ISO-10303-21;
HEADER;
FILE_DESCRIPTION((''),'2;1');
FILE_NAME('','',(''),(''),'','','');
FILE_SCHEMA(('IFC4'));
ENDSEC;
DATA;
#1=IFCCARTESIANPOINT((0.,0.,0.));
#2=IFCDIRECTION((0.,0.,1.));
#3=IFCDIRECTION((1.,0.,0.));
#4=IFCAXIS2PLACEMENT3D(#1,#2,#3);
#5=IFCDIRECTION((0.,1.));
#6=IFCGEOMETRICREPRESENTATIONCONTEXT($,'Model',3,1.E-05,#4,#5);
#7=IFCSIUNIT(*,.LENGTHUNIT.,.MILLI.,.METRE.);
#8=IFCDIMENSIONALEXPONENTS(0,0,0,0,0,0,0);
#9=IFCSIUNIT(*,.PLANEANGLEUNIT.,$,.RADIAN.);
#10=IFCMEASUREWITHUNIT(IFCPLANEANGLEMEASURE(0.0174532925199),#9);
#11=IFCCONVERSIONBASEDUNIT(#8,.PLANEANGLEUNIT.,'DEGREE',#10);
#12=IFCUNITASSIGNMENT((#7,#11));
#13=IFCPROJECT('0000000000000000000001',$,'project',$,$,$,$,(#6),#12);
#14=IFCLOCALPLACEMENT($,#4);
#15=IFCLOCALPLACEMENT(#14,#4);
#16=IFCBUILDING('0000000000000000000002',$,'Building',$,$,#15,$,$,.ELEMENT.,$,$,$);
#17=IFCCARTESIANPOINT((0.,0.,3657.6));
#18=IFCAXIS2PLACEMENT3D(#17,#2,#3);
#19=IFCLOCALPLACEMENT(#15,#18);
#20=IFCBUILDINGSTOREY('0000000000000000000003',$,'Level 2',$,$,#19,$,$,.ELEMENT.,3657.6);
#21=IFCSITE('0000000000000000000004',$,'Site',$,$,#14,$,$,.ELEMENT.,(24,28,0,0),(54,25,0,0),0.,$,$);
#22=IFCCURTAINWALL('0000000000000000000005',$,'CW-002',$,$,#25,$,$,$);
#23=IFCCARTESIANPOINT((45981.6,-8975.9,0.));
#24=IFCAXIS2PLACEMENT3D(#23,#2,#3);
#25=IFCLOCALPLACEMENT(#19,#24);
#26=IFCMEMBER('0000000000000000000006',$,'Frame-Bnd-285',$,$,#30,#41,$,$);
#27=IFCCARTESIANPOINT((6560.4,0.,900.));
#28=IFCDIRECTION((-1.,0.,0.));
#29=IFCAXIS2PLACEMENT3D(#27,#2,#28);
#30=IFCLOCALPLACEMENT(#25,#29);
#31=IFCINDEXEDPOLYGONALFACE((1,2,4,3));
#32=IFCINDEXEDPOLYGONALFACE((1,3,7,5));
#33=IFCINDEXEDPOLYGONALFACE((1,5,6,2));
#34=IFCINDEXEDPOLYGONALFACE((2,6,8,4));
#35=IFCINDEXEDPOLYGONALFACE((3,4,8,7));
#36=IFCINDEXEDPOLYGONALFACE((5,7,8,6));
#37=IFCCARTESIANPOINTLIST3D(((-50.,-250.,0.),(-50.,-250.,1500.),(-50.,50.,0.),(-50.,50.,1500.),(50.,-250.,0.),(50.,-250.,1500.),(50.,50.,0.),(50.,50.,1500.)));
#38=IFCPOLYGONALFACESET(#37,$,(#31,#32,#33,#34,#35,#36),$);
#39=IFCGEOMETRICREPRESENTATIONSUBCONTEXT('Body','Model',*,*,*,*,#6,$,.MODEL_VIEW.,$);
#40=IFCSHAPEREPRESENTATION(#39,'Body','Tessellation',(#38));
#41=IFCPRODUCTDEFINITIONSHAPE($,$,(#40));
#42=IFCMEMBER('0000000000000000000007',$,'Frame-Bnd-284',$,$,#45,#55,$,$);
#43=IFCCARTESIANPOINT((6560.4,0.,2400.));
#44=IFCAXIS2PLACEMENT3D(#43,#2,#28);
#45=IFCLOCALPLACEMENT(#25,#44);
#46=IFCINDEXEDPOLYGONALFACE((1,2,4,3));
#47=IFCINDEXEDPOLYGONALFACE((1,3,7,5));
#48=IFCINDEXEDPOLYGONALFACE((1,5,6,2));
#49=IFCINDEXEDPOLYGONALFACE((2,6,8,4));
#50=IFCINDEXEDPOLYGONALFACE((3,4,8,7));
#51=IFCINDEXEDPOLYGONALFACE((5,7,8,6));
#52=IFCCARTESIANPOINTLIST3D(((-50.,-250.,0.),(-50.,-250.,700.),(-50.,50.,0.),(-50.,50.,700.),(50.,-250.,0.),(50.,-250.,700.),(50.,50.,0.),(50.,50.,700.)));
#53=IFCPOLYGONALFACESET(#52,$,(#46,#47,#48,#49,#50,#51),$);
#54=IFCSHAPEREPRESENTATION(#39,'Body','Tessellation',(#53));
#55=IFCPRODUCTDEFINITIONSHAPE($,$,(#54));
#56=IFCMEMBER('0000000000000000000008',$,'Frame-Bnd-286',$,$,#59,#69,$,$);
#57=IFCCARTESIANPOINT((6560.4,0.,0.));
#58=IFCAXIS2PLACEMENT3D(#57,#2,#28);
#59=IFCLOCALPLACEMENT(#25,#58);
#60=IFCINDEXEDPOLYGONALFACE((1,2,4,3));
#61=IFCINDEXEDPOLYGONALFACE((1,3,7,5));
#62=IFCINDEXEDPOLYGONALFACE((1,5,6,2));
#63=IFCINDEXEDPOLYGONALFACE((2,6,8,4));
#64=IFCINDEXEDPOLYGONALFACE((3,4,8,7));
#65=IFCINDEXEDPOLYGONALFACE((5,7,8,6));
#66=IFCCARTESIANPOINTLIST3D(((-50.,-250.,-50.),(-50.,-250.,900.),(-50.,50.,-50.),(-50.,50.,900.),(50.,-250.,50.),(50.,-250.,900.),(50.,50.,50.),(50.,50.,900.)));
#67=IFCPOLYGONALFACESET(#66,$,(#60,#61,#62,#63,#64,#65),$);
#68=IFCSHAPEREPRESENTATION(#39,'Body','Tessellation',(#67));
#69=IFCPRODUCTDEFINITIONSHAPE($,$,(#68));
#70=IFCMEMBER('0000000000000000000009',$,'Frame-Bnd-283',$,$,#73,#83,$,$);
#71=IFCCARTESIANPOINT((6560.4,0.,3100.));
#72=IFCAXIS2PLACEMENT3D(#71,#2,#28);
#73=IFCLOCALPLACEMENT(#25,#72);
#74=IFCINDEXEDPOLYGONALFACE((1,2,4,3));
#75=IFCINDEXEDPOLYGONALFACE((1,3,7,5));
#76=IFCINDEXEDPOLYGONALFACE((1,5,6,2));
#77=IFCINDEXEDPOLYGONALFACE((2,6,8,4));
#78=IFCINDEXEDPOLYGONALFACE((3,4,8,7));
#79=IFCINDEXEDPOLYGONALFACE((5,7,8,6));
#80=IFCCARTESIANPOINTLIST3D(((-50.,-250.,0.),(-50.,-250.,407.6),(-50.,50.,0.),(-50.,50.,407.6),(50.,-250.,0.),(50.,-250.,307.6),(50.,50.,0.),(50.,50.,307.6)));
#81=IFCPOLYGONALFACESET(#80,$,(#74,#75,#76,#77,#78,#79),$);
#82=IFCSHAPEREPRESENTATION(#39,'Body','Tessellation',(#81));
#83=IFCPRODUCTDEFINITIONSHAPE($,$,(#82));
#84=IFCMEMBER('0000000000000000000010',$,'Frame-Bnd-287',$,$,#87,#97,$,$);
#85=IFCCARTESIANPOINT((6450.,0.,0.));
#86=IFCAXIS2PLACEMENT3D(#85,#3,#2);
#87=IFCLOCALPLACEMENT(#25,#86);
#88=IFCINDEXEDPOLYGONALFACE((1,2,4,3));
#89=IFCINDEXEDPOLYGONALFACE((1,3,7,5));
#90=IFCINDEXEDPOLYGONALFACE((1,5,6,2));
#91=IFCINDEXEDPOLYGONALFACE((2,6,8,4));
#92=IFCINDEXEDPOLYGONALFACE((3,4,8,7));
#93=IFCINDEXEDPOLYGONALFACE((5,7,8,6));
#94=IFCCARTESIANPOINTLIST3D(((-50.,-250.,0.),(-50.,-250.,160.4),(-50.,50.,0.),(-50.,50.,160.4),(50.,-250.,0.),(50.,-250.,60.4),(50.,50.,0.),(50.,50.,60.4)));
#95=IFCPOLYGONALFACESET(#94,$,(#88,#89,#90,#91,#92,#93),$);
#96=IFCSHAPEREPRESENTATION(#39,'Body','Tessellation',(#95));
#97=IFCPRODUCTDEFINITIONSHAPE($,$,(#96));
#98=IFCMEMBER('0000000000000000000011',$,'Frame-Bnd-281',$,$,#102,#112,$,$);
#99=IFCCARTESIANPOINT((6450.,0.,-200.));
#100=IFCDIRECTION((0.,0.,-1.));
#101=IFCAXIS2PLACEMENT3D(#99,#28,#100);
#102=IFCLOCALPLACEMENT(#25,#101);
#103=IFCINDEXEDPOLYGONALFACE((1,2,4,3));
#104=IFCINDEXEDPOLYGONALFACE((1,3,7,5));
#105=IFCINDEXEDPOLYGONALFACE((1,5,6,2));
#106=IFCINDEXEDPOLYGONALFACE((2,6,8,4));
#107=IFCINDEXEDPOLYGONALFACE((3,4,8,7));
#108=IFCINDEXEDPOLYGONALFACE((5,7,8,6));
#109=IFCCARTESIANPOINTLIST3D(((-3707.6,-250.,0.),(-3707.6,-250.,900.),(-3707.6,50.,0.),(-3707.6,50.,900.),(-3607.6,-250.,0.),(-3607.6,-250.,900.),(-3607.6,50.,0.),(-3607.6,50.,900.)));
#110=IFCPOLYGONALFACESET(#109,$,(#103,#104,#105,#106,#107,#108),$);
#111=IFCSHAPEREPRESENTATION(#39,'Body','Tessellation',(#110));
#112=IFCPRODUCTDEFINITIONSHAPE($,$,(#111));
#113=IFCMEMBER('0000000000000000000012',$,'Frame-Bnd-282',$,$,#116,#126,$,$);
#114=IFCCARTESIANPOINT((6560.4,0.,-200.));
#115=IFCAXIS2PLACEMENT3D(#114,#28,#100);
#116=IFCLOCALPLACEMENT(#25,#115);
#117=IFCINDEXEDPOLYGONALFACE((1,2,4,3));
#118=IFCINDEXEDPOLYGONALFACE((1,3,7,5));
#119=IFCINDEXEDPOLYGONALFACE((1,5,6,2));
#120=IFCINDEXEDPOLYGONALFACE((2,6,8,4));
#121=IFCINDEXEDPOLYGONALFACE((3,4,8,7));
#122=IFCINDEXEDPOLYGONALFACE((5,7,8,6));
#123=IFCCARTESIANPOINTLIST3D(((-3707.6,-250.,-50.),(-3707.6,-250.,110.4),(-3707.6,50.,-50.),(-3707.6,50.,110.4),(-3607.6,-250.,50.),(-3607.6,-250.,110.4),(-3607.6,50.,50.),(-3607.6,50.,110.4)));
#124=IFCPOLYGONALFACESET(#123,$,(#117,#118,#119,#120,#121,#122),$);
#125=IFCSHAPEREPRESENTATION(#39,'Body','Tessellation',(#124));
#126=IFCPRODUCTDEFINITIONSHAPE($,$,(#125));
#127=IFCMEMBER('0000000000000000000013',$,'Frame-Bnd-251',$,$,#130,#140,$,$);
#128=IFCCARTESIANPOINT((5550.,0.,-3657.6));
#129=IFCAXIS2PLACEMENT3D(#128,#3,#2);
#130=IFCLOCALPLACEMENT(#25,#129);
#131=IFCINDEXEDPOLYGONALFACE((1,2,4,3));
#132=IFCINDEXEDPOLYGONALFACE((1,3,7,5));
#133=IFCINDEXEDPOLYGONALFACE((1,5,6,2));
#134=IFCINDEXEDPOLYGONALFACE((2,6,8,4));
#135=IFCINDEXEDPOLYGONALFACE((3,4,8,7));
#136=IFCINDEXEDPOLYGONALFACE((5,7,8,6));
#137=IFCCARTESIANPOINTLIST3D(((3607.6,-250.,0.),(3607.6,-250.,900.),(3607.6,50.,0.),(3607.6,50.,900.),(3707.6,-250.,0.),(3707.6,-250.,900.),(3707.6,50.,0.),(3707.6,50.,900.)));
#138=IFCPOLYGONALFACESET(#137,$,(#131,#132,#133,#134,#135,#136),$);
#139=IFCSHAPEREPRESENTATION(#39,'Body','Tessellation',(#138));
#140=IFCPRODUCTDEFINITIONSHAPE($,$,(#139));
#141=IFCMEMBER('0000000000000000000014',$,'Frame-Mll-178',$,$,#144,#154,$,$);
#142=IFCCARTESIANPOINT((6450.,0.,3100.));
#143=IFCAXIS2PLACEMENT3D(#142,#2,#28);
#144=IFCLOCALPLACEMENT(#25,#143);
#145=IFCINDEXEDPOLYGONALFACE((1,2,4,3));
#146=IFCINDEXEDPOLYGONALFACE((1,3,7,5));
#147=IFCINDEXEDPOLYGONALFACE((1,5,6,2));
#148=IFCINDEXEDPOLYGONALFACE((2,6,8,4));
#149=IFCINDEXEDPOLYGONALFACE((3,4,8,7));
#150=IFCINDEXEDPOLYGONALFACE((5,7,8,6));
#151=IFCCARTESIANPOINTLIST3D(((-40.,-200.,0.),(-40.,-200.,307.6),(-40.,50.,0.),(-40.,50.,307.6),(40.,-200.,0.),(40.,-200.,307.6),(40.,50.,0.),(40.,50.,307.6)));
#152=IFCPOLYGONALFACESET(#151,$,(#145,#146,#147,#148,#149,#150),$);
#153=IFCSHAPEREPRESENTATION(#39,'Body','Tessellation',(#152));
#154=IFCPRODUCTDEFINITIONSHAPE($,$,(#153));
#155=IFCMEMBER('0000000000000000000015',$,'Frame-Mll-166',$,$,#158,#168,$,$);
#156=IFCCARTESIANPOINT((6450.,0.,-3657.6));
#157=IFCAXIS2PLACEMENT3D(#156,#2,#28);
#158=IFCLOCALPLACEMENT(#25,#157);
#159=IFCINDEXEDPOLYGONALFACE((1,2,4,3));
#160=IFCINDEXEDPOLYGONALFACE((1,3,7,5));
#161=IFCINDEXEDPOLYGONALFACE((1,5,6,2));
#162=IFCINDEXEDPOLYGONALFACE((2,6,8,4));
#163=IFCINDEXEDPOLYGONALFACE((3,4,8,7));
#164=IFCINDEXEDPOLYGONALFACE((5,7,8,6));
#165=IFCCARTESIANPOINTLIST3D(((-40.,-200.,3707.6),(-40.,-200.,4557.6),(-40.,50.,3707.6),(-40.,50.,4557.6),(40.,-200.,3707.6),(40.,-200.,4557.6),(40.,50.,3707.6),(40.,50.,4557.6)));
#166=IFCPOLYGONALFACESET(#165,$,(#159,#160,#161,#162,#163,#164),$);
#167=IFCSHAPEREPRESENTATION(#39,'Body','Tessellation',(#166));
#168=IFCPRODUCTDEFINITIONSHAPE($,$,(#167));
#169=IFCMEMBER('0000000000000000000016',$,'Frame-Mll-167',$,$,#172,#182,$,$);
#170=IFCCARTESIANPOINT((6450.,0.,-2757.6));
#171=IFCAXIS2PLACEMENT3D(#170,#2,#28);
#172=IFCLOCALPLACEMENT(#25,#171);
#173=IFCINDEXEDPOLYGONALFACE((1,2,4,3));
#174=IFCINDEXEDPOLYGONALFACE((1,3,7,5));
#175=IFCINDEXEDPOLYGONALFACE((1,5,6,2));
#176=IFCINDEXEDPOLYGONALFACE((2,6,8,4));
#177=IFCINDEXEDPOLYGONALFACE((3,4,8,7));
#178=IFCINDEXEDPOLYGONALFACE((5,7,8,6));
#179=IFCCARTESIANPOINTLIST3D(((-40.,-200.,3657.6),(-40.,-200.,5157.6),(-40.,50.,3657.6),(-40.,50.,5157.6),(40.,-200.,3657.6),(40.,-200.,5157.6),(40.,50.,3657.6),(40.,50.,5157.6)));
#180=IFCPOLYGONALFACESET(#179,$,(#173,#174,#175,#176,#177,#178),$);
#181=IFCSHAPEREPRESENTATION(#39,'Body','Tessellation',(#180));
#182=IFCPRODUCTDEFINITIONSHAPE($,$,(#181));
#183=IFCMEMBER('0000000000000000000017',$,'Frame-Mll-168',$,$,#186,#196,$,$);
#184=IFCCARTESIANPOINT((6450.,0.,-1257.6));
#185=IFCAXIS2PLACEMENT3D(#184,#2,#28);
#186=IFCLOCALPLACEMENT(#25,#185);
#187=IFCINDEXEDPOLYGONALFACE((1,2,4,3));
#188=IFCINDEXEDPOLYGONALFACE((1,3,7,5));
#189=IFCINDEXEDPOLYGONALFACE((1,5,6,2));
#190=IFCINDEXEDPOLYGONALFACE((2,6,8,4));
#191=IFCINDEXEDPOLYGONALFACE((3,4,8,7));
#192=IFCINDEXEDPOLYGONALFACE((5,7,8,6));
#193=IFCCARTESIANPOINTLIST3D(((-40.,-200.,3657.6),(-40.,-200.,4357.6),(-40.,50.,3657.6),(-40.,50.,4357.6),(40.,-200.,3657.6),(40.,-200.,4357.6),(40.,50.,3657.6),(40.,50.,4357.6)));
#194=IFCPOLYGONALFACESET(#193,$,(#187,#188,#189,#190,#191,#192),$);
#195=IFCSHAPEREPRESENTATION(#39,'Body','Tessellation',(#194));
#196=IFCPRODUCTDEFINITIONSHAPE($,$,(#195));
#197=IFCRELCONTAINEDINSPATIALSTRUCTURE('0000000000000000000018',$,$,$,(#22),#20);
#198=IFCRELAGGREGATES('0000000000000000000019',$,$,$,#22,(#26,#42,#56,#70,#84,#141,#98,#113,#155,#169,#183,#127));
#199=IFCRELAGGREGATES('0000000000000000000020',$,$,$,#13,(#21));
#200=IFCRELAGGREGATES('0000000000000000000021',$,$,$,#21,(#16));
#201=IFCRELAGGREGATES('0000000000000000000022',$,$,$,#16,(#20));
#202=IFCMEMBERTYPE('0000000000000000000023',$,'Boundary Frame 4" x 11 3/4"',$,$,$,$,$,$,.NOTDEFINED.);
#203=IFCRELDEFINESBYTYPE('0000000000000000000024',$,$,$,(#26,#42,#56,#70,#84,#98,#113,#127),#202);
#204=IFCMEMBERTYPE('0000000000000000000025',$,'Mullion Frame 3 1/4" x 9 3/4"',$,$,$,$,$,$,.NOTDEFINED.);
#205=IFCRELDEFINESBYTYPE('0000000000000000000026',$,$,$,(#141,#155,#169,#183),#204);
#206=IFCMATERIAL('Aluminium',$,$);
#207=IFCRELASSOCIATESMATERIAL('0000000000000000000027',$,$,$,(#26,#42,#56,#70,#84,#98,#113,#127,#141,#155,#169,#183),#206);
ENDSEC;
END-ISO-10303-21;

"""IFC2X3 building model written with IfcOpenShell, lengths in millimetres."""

from ifc_helpers import new_model, entity, si_unit, converted_unit, direction, frame, origin_with_axes, place, context, subcontext, project, spatial, polyline, outline, extrude, clip, halfspace, material, type_object, element, aggregate, save


model = new_model("IFC2X3")

# Units and contexts
model_context = context("Model", 3, precision=1e-05, world=origin_with_axes(), true_north=direction((0.0, 1.0)))
body_context = subcontext(model_context, "Body", "Model", "MODEL_VIEW")
ifc_project = project(units=[si_unit("LENGTHUNIT", "METRE", prefix="MILLI"), converted_unit("PLANEANGLEUNIT", "DEGREE", entity("IfcPlaneAngleMeasure", 0.0174532925199), si_unit("PLANEANGLEUNIT", "RADIAN"), dimensions=[0, 0, 0, 0, 0, 0, 0])], contexts=[model_context])

# Site, building, storey
site_placement = place(None, origin_with_axes())
site = spatial("IfcSite", under=ifc_project, at=site_placement, Name="Site", CompositionType="ELEMENT", RefLatitude=(24, 28, 0, 0), RefLongitude=(54, 25, 0, 0), RefElevation=0.0)
building_placement = place(site_placement, origin_with_axes())
building = spatial("IfcBuilding", under=site, at=building_placement, Name="Building", CompositionType="ELEMENT")
storey_placement = place(building_placement, frame((0.0, 0.0, 3657.6), z_axis=(0.0, 0.0, 1.0), x_axis=(1.0, 0.0, 0.0)))
storey = spatial("IfcBuildingStorey", under=building, at=storey_placement, Name="Level 2", CompositionType="ELEMENT", Elevation=3657.6)

# Curtain wall, members
curtain_wall_placement = place(storey_placement, frame((45981.6, -8975.9, 0.0), z_axis=(0.0, 0.0, 1.0), x_axis=(1.0, 0.0, 0.0)))
curtain_wall = element("IfcCurtainWall", 1, at=curtain_wall_placement, inside=storey, Name="CW-002")
ifc_material_1 = material(Name="Aluminium")
member_type_1 = type_object("IfcMemberType", Name="Boundary Frame 4\" x 11 3/4\"", PredefinedType="NOTDEFINED")
member_1_placement = place(curtain_wall_placement, frame((6560.4, 0.0, 900.0), z_axis=(0.0, 0.0, 1.0), x_axis=(-1.0, 0.0, 0.0)))
member_1 = element("IfcMember", 2, at=member_1_placement, type_object=member_type_1, material=ifc_material_1, Name="Frame-Bnd-285", context=body_context, shape_type="SweptSolid", body=[
    extrude(outline(polyline([(-50.0, 250.0), (-50.0, -50.0), (50.0, -50.0), (50.0, 250.0), (-50.0, 250.0)])), frame((0.0, 0.0, 0.0), z_axis=(0.0, 0.0, 1.0), x_axis=(-1.0, 0.0, 0.0)), (0.0, 0.0, 1.0), 1500.0),
])
member_2_placement = place(curtain_wall_placement, frame((6560.4, 0.0, 2400.0), z_axis=(0.0, 0.0, 1.0), x_axis=(-1.0, 0.0, 0.0)))
member_2 = element("IfcMember", 3, at=member_2_placement, type_object=member_type_1, material=ifc_material_1, Name="Frame-Bnd-284", context=body_context, shape_type="SweptSolid", body=[
    extrude(outline(polyline([(-50.0, 250.0), (-50.0, -50.0), (50.0, -50.0), (50.0, 250.0), (-50.0, 250.0)])), frame((0.0, 0.0, 0.0), z_axis=(0.0, 0.0, 1.0), x_axis=(-1.0, 0.0, 0.0)), (0.0, 0.0, 1.0), 700.0),
])
member_3_placement = place(curtain_wall_placement, frame((6560.4, 0.0, 0.0), z_axis=(0.0, 0.0, 1.0), x_axis=(-1.0, 0.0, 0.0)))
member_3 = element("IfcMember", 4, at=member_3_placement, type_object=member_type_1, material=ifc_material_1, Name="Frame-Bnd-286", context=body_context, shape_type="Clipping", body=[
    clip(extrude(outline(polyline([(-50.0, 250.0), (-50.0, -50.0), (50.0, -50.0), (50.0, 250.0), (-50.0, 250.0)])), frame((0.0, 0.0, -50.0), z_axis=(0.0, 0.0, 1.0), x_axis=(-1.0, 0.0, 0.0)), (0.0, 0.0, 1.0), 950.0), halfspace(frame((0.0, 0.0, 0.0), z_axis=(-0.707107, 0.0, 0.707107), x_axis=(0.0, -1.0, 0.0)), True)),
])
member_4_placement = place(curtain_wall_placement, frame((6560.4, 0.0, 3100.0), z_axis=(0.0, 0.0, 1.0), x_axis=(-1.0, 0.0, 0.0)))
member_4 = element("IfcMember", 5, at=member_4_placement, type_object=member_type_1, material=ifc_material_1, Name="Frame-Bnd-283", context=body_context, shape_type="Clipping", body=[
    clip(extrude(outline(polyline([(-50.0, 250.0), (-50.0, -50.0), (50.0, -50.0), (50.0, 250.0), (-50.0, 250.0)])), frame((0.0, 0.0, 0.0), z_axis=(0.0, 0.0, 1.0), x_axis=(-1.0, 0.0, 0.0)), (0.0, 0.0, 1.0), 407.6), halfspace(frame((178.8, 0.0, 178.8), z_axis=(-0.707107, 0.0, -0.707107), x_axis=(0.0, 1.0, 0.0)), True)),
])
member_5_placement = place(curtain_wall_placement, frame((6450.0, 0.0, 0.0), z_axis=(1.0, 0.0, 0.0), x_axis=(0.0, 0.0, 1.0)))
member_5 = element("IfcMember", 6, at=member_5_placement, type_object=member_type_1, material=ifc_material_1, Name="Frame-Bnd-287", context=body_context, shape_type="Clipping", body=[
    clip(extrude(outline(polyline([(-250.0, -50.0), (50.0, -50.0), (50.0, 50.0), (-250.0, 50.0), (-250.0, -50.0)])), frame((0.0, 0.0, 0.0), z_axis=(0.0, 0.0, 1.0), x_axis=(0.0, 1.0, 0.0)), (0.0, 0.0, 1.0), 160.4), halfspace(frame((55.2, 0.0, 55.2), z_axis=(-0.707107, 0.0, -0.707107), x_axis=(0.0, 1.0, 0.0)), True)),
])
member_6_placement = place(curtain_wall_placement, frame((6450.0, 0.0, -200.0), z_axis=(-1.0, 0.0, 0.0), x_axis=(0.0, 0.0, -1.0)))
member_6 = element("IfcMember", 7, at=member_6_placement, type_object=member_type_1, material=ifc_material_1, Name="Frame-Bnd-281", context=body_context, shape_type="SweptSolid", body=[
    extrude(outline(polyline([(250.0, -3607.6), (-50.0, -3607.6), (-50.0, -3707.6), (250.0, -3707.6), (250.0, -3607.6)])), frame((0.0, 0.0, 0.0), z_axis=(0.0, 0.0, 1.0), x_axis=(0.0, -1.0, 0.0)), (0.0, 0.0, 1.0), 900.0),
])
member_7_placement = place(curtain_wall_placement, frame((6560.4, 0.0, -200.0), z_axis=(-1.0, 0.0, 0.0), x_axis=(0.0, 0.0, -1.0)))
member_7 = element("IfcMember", 8, at=member_7_placement, type_object=member_type_1, material=ifc_material_1, Name="Frame-Bnd-282", context=body_context, shape_type="Clipping", body=[
    clip(extrude(outline(polyline([(250.0, -3607.6), (-50.0, -3607.6), (-50.0, -3707.6), (250.0, -3707.6), (250.0, -3607.6)])), frame((0.0, 0.0, -50.0), z_axis=(0.0, 0.0, 1.0), x_axis=(0.0, -1.0, 0.0)), (0.0, 0.0, 1.0), 160.4), halfspace(frame((-1828.8, 0.0, 1828.8), z_axis=(-0.707107, 0.0, 0.707107), x_axis=(0.0, -1.0, 0.0)), True)),
])
member_8_placement = place(curtain_wall_placement, frame((5550.0, 0.0, -3657.6), z_axis=(1.0, 0.0, 0.0), x_axis=(0.0, 0.0, 1.0)))
member_8 = element("IfcMember", 9, at=member_8_placement, type_object=member_type_1, material=ifc_material_1, Name="Frame-Bnd-251", context=body_context, shape_type="SweptSolid", body=[
    extrude(outline(polyline([(-250.0, -3707.6), (50.0, -3707.6), (50.0, -3607.6), (-250.0, -3607.6), (-250.0, -3707.6)])), frame((0.0, 0.0, 0.0), z_axis=(0.0, 0.0, 1.0), x_axis=(0.0, 1.0, 0.0)), (0.0, 0.0, 1.0), 900.0),
])
member_type_2 = type_object("IfcMemberType", Name="Mullion Frame 3 1/4\" x 9 3/4\"", PredefinedType="NOTDEFINED")
member_9_placement = place(curtain_wall_placement, frame((6450.0, 0.0, 3100.0), z_axis=(0.0, 0.0, 1.0), x_axis=(-1.0, 0.0, 0.0)))
member_9 = element("IfcMember", 10, at=member_9_placement, type_object=member_type_2, material=ifc_material_1, Name="Frame-Mll-178", context=body_context, shape_type="SweptSolid", body=[
    extrude(outline(polyline([(-40.0, 200.0), (-40.0, -50.0), (40.0, -50.0), (40.0, 200.0), (-40.0, 200.0)])), frame((0.0, 0.0, 0.0), z_axis=(0.0, 0.0, 1.0), x_axis=(-1.0, 0.0, 0.0)), (0.0, 0.0, 1.0), 307.6),
])
member_10_placement = place(curtain_wall_placement, frame((6450.0, 0.0, -3657.6), z_axis=(0.0, 0.0, 1.0), x_axis=(-1.0, 0.0, 0.0)))
member_10 = element("IfcMember", 11, at=member_10_placement, type_object=member_type_2, material=ifc_material_1, Name="Frame-Mll-166", context=body_context, shape_type="SweptSolid", body=[
    extrude(outline(polyline([(-40.0, 200.0), (-40.0, -50.0), (40.0, -50.0), (40.0, 200.0), (-40.0, 200.0)])), frame((0.0, 0.0, 3707.6), z_axis=(0.0, 0.0, 1.0), x_axis=(-1.0, 0.0, 0.0)), (0.0, 0.0, 1.0), 850.0),
])
member_11_placement = place(curtain_wall_placement, frame((6450.0, 0.0, -2757.6), z_axis=(0.0, 0.0, 1.0), x_axis=(-1.0, 0.0, 0.0)))
member_11 = element("IfcMember", 12, at=member_11_placement, type_object=member_type_2, material=ifc_material_1, Name="Frame-Mll-167", context=body_context, shape_type="SweptSolid", body=[
    extrude(outline(polyline([(-40.0, 200.0), (-40.0, -50.0), (40.0, -50.0), (40.0, 200.0), (-40.0, 200.0)])), frame((0.0, 0.0, 3657.6), z_axis=(0.0, 0.0, 1.0), x_axis=(-1.0, 0.0, 0.0)), (0.0, 0.0, 1.0), 1500.0),
])
member_12_placement = place(curtain_wall_placement, frame((6450.0, 0.0, -1257.6), z_axis=(0.0, 0.0, 1.0), x_axis=(-1.0, 0.0, 0.0)))
member_12 = element("IfcMember", 13, at=member_12_placement, type_object=member_type_2, material=ifc_material_1, Name="Frame-Mll-168", context=body_context, shape_type="SweptSolid", body=[
    extrude(outline(polyline([(-40.0, 200.0), (-40.0, -50.0), (40.0, -50.0), (40.0, 200.0), (-40.0, 200.0)])), frame((0.0, 0.0, 3657.6), z_axis=(0.0, 0.0, 1.0), x_axis=(-1.0, 0.0, 0.0)), (0.0, 0.0, 1.0), 700.0),
])
aggregate(curtain_wall, [member_1, member_2, member_3, member_4, member_5, member_9, member_6, member_7, member_10, member_11, member_12, member_8])

save(model, "model.ifc")
